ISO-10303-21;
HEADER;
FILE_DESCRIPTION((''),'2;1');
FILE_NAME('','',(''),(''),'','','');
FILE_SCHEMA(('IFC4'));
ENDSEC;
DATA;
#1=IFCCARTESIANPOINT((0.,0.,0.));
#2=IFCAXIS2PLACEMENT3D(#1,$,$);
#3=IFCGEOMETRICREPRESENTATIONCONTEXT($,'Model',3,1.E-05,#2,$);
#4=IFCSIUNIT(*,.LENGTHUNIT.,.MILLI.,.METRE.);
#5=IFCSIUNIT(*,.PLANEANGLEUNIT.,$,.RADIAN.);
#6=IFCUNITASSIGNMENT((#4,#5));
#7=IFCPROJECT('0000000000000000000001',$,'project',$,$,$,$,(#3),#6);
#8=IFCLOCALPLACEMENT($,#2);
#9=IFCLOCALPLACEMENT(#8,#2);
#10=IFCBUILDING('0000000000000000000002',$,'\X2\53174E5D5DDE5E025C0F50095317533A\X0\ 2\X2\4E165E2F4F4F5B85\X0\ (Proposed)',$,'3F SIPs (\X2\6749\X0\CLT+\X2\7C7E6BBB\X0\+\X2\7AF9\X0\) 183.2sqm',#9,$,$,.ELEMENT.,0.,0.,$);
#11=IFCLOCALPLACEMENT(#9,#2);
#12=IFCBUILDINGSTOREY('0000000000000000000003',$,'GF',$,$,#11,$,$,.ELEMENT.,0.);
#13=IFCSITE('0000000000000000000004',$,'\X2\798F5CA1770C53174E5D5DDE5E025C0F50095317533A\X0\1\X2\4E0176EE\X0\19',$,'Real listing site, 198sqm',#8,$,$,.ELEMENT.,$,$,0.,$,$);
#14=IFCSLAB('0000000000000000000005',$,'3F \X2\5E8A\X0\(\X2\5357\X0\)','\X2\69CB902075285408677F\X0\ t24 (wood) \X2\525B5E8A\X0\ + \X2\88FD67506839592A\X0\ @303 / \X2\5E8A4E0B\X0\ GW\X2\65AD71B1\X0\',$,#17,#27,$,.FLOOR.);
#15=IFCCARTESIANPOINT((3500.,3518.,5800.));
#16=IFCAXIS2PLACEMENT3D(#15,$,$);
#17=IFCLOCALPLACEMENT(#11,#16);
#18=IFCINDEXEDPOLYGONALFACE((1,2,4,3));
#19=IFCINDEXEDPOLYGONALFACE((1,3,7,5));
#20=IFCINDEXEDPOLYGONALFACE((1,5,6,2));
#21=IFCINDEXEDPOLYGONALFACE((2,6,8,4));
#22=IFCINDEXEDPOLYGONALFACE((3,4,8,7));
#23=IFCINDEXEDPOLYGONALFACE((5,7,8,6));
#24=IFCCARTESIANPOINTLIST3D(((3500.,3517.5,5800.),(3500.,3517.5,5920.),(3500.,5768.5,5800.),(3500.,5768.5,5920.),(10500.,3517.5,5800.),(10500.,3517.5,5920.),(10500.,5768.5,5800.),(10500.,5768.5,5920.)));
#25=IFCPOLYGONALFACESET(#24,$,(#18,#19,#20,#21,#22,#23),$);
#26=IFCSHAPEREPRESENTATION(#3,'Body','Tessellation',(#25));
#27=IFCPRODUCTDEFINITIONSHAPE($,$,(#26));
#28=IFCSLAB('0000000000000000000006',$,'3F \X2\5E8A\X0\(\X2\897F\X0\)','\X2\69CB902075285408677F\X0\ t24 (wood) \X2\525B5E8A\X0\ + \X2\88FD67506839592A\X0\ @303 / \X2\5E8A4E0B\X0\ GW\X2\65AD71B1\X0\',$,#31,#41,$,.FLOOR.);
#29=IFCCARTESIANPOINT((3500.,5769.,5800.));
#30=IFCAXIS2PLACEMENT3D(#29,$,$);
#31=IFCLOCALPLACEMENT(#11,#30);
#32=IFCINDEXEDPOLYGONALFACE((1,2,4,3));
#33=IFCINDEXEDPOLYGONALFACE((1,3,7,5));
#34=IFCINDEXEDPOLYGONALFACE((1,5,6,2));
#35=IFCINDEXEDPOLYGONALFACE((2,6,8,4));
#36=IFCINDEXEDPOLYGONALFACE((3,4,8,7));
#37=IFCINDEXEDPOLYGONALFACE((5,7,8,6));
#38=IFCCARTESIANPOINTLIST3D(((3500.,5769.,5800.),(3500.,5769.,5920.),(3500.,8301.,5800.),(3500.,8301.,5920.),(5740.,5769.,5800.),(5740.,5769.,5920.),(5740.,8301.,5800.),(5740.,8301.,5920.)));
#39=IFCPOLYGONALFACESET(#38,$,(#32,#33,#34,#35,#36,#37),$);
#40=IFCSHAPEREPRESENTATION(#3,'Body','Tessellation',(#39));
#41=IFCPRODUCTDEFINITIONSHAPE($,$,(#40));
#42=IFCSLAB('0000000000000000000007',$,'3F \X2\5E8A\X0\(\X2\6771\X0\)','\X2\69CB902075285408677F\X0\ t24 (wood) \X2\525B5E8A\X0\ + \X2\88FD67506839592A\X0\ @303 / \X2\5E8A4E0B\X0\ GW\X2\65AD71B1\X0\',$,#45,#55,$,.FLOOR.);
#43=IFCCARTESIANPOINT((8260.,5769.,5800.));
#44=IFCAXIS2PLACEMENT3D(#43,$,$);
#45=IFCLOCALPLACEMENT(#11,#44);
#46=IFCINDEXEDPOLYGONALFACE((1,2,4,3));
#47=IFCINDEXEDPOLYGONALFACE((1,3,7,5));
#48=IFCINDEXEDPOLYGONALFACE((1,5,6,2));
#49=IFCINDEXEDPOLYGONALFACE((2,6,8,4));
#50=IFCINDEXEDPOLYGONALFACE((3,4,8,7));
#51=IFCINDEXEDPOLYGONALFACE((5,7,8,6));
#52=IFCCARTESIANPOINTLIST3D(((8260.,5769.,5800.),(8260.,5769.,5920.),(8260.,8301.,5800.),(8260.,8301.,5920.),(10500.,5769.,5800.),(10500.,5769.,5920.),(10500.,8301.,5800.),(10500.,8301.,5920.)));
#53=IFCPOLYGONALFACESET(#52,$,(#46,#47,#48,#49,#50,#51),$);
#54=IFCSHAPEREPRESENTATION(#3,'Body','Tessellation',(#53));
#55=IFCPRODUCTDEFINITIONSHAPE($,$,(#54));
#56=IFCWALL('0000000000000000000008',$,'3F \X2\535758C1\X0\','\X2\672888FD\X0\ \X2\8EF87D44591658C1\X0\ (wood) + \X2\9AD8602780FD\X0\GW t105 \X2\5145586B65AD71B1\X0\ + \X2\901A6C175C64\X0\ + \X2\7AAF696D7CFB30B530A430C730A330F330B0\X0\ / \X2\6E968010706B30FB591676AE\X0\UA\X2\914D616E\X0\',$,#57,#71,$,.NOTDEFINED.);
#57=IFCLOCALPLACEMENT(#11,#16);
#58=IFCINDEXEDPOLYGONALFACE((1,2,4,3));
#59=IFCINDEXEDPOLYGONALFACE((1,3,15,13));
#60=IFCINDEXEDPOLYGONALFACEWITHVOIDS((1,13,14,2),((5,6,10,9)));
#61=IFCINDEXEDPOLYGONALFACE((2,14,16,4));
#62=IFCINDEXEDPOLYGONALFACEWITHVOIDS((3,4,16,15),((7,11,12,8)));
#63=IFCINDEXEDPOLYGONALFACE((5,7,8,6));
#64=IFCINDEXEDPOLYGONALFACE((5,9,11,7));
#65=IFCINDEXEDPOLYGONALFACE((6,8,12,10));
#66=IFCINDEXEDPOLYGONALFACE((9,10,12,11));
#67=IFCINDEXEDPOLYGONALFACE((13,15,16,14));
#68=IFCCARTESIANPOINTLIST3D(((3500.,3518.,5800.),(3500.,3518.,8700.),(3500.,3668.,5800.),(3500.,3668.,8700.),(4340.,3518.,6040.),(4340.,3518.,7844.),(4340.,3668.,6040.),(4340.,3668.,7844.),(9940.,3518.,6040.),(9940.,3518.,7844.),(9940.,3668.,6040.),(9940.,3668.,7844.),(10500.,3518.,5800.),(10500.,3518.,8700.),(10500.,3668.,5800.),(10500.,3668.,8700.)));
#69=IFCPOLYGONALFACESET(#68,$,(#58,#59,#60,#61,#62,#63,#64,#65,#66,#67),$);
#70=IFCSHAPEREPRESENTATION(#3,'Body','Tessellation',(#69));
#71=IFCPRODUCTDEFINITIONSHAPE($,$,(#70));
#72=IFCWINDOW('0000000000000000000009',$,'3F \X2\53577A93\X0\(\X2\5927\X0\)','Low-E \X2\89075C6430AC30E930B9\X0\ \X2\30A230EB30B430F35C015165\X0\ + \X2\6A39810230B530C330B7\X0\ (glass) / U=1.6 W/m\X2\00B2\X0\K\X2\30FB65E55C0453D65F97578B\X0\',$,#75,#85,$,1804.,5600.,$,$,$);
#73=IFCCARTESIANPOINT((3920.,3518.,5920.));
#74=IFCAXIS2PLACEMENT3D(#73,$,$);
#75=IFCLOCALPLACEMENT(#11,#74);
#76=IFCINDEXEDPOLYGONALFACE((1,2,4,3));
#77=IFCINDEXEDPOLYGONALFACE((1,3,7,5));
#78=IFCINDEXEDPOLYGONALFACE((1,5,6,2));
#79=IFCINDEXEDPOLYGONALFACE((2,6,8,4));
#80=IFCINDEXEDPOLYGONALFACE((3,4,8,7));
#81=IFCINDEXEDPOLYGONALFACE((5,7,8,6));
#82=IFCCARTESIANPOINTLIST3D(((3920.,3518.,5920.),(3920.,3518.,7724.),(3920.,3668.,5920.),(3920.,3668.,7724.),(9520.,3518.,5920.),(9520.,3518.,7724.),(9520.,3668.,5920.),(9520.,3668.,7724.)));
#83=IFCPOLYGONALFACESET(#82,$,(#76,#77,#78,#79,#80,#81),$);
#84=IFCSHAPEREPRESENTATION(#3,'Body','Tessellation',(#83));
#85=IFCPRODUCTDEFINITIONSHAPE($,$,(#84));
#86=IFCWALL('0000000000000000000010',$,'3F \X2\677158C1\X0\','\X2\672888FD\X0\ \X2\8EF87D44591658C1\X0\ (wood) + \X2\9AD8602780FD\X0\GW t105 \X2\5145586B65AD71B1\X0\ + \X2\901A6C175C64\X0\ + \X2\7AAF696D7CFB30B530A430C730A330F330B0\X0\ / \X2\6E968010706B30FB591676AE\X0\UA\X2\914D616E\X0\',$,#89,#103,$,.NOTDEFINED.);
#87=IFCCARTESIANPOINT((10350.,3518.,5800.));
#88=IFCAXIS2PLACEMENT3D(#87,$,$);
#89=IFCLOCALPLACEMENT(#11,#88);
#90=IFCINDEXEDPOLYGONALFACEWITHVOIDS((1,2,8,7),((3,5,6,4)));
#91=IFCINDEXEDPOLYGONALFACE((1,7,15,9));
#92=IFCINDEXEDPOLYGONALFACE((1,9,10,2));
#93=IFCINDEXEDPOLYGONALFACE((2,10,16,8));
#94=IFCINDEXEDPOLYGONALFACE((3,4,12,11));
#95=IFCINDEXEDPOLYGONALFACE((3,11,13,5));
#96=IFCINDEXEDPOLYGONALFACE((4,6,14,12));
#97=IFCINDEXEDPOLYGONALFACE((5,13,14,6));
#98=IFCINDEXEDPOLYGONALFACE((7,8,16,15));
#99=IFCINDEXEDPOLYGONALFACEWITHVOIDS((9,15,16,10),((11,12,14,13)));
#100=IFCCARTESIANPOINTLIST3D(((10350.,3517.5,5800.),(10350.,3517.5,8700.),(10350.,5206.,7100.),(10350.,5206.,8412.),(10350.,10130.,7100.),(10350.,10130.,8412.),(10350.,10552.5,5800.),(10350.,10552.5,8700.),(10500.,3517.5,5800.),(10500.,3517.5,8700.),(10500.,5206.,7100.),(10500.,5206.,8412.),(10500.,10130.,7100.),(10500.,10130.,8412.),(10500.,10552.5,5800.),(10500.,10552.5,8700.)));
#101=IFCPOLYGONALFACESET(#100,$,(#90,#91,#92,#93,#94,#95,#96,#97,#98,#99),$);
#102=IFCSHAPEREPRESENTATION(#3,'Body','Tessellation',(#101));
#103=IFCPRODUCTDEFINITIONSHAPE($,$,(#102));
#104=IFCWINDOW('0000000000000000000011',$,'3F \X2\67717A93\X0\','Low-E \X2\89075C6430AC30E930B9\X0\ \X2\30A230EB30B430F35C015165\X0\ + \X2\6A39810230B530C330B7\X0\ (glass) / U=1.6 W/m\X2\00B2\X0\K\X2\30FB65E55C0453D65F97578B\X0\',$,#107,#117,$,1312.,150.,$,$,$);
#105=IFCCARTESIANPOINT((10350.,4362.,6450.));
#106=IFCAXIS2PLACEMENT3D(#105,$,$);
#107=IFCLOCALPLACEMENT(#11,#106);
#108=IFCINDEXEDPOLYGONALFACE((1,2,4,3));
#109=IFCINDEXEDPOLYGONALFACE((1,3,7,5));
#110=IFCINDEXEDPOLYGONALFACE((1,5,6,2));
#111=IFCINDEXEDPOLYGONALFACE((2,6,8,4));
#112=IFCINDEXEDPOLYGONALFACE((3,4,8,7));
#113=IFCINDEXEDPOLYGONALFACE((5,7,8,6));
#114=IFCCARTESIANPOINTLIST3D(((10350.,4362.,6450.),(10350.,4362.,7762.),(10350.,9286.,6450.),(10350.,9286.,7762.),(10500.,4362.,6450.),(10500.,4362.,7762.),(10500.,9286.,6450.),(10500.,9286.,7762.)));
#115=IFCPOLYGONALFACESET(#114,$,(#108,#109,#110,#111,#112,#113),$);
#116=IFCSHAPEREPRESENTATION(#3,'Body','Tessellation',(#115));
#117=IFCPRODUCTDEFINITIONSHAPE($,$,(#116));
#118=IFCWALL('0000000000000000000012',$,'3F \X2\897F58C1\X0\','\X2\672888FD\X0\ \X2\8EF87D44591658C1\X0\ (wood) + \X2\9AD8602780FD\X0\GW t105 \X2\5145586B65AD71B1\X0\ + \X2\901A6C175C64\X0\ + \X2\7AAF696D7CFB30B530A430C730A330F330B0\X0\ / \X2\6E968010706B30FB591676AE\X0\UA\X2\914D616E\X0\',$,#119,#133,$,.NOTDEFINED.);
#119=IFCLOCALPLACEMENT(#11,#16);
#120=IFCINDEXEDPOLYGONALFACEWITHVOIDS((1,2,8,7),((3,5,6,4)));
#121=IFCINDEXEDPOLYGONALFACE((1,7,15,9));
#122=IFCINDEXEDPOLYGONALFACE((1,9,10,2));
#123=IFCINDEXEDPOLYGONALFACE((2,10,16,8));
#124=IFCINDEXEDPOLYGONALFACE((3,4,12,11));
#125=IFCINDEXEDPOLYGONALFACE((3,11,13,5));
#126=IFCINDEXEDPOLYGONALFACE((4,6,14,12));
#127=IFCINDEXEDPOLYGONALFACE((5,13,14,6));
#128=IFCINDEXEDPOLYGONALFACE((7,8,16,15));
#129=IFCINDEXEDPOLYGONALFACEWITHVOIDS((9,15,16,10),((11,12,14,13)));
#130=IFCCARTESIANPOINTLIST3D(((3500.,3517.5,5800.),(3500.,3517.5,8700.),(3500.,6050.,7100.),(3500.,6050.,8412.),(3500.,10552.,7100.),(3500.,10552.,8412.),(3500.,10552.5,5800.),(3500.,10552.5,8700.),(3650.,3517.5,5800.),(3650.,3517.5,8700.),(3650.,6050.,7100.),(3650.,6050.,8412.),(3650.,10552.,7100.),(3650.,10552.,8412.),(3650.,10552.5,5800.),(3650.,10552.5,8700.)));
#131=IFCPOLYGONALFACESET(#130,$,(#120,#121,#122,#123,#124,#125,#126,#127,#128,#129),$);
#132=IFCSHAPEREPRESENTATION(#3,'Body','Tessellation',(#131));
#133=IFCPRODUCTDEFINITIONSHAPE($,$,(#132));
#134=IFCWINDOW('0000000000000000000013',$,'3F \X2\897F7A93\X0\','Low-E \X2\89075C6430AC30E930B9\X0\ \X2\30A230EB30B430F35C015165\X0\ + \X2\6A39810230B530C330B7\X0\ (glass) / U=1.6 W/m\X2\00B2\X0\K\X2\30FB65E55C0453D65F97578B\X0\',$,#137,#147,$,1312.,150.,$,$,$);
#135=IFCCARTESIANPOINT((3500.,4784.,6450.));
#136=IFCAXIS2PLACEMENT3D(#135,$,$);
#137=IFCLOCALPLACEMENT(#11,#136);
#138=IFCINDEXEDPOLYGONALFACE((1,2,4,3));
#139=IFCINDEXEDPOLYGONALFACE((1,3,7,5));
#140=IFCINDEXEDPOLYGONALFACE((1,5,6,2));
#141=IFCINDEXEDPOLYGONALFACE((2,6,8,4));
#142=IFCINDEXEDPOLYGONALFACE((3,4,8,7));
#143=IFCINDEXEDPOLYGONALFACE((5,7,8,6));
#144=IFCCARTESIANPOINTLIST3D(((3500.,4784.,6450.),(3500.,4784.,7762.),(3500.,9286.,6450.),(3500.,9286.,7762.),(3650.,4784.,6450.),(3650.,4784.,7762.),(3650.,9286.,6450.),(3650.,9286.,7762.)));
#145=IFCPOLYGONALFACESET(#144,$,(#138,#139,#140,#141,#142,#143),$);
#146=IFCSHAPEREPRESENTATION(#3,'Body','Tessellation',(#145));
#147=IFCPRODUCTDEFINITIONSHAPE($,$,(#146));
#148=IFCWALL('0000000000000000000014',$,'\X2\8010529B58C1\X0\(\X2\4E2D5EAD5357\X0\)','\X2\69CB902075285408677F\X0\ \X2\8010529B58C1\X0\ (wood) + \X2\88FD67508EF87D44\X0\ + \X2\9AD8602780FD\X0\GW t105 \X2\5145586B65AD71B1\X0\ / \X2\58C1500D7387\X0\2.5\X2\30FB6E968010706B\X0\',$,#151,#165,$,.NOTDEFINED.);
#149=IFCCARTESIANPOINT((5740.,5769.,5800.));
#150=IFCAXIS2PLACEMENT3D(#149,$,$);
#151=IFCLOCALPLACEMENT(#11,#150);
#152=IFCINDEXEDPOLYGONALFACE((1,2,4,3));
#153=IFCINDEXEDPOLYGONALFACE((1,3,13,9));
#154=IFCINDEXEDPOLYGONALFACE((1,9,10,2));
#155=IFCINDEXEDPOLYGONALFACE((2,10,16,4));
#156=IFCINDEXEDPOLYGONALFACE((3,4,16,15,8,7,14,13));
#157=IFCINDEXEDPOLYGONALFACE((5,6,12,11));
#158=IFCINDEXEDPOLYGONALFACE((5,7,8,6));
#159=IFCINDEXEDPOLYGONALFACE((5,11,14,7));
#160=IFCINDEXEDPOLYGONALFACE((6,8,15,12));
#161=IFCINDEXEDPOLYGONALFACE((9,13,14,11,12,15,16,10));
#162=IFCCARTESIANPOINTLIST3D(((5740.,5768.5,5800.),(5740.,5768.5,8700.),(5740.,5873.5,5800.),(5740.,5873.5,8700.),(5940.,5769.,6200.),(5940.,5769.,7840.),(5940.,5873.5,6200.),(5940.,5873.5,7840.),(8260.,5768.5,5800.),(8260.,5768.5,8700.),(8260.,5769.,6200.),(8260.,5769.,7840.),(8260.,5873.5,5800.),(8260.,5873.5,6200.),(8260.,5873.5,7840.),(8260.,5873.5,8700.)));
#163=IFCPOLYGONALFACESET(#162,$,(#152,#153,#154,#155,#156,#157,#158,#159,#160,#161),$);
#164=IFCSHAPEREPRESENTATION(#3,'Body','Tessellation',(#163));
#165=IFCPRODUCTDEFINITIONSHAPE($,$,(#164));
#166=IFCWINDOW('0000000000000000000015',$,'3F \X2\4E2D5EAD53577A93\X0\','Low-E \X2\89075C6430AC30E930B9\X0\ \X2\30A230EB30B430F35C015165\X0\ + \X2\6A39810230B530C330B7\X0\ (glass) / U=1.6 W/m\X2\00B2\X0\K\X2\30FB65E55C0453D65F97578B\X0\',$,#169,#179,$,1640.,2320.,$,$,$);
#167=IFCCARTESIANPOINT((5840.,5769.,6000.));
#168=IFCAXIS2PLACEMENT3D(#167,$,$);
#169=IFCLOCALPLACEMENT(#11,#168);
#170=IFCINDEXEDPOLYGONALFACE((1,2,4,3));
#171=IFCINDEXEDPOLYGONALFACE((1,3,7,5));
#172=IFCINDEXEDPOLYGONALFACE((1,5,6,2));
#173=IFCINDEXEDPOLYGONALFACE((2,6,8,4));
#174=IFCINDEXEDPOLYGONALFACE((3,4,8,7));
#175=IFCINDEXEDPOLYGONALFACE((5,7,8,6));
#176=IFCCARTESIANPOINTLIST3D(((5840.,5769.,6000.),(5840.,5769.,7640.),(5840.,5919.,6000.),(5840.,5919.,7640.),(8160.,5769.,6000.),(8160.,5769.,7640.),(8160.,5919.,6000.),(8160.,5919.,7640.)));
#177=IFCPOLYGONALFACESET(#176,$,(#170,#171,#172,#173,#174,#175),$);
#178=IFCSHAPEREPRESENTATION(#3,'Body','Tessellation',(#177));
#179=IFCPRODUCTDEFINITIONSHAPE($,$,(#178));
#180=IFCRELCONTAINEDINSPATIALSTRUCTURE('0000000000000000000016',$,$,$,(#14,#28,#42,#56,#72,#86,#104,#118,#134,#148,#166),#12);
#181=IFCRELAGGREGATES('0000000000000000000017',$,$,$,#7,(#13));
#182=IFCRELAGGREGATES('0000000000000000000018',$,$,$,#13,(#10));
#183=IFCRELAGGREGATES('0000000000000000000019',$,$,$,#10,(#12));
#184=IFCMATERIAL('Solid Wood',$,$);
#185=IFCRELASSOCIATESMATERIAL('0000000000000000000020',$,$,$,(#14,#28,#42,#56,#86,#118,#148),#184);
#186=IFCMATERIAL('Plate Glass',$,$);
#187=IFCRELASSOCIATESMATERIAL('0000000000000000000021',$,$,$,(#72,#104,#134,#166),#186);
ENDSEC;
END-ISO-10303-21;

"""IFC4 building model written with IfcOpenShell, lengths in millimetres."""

from ifc_helpers import new_model, si_unit, frame, frame_2d, origin, place, context, project, spatial, rectangle, extrude, material, element, fill, save


model = new_model("IFC4")

# Units and contexts
model_context = context("Model", 3, precision=1e-05, world=origin())
ifc_project = project(units=[si_unit("LENGTHUNIT", "METRE", prefix="MILLI"), si_unit("PLANEANGLEUNIT", "RADIAN")], contexts=[model_context])

# Site, building, storey
site_placement = place(None, origin())
site = spatial("IfcSite", under=ifc_project, at=site_placement, Name="福岡県北九州市小倉北区1丁目19", ObjectType="Real listing site, 198sqm", CompositionType="ELEMENT", RefElevation=0.0)
building_placement = place(site_placement, origin())
building = spatial("IfcBuilding", under=site, at=building_placement, Name="北九州市小倉北区 2世帯住宅 (Proposed)", ObjectType="3F SIPs (杉CLT+籾殻+竹) 183.2sqm", CompositionType="ELEMENT", ElevationOfRefHeight=0.0, ElevationOfTerrain=0.0)
storey_placement = place(building_placement, origin())
storey = spatial("IfcBuildingStorey", under=building, at=storey_placement, Name="GF", CompositionType="ELEMENT", Elevation=0.0)

# Slabs
ifc_material_1 = material(Name="Solid Wood")
slab_1_placement = place(storey_placement, frame((3500.0, 3518.0, 5800.0)))
element("IfcSlab", 1, at=slab_1_placement, inside=storey, material=ifc_material_1, Name="3F 床(南)", Description="構造用合板 t24 (wood) 剛床 + 製材根太 @303 / 床下 GW断熱", PredefinedType="FLOOR", context=model_context, shape_type="SweptSolid", body=[
    extrude(rectangle(XDim=7000.0, YDim=2251.0, at=frame_2d((3500.0, 1125.0))), frame((3500.0, 3518.0, 5800.0)), (0.0, 0.0, 1.0), 120.0),
])
slab_2_placement = place(storey_placement, frame((3500.0, 5769.0, 5800.0)))
element("IfcSlab", 2, at=slab_2_placement, inside=storey, material=ifc_material_1, Name="3F 床(西)", Description="構造用合板 t24 (wood) 剛床 + 製材根太 @303 / 床下 GW断熱", PredefinedType="FLOOR", context=model_context, shape_type="SweptSolid", body=[
    extrude(rectangle(XDim=2240.0, YDim=2532.0, at=frame_2d((1120.0, 1266.0))), frame((3500.0, 5769.0, 5800.0)), (0.0, 0.0, 1.0), 120.0),
])
slab_3_placement = place(storey_placement, frame((8260.0, 5769.0, 5800.0)))
element("IfcSlab", 3, at=slab_3_placement, inside=storey, material=ifc_material_1, Name="3F 床(東)", Description="構造用合板 t24 (wood) 剛床 + 製材根太 @303 / 床下 GW断熱", PredefinedType="FLOOR", context=model_context, shape_type="SweptSolid", body=[
    extrude(rectangle(XDim=2240.0, YDim=2532.0, at=frame_2d((1120.0, 1266.0))), frame((8260.0, 5769.0, 5800.0)), (0.0, 0.0, 1.0), 120.0),
])

# Walls, openings, windows
wall_1_placement = place(storey_placement, frame((3500.0, 3518.0, 5800.0)))
wall_1 = element("IfcWall", 4, at=wall_1_placement, inside=storey, material=ifc_material_1, Name="3F 南壁", Description="木製 軸組外壁 (wood) + 高性能GW t105 充填断熱 + 通気層 + 窯業系サイディング / 準耐火・外皮UA配慮", PredefinedType="NOTDEFINED", context=model_context, shape_type="SweptSolid", body=[
    extrude(rectangle(XDim=7000.0, YDim=150.0, at=frame_2d((3500.0, 75.0))), frame((3500.0, 3518.0, 5800.0)), (0.0, 0.0, 1.0), 2900.0),
])
opening_1_placement = place(storey_placement, frame((3920.0, 3518.0, 5920.0)))
opening_1 = element("IfcOpeningElement", 5, at=opening_1_placement, cuts=wall_1, PredefinedType="NOTDEFINED", context=model_context, shape_type="SweptSolid", body=[
    extrude(rectangle(XDim=5600.0, YDim=150.0, at=frame_2d((2800.0, 75.0))), frame((3920.0, 3518.0, 5920.0)), (0.0, 0.0, 1.0), 1804.0),
])
ifc_material_2 = material(Name="Plate Glass")
window_1_placement = place(storey_placement, frame((3920.0, 3518.0, 5920.0)))
window_1 = element("IfcWindow", 6, at=window_1_placement, inside=storey, material=ifc_material_2, Name="3F 南窓(大)", Description="Low-E 複層ガラス アルゴン封入 + 樹脂サッシ (glass) / U=1.6 W/m²K・日射取得型", OverallHeight=1804.0, OverallWidth=5600.0, context=model_context, shape_type="SweptSolid", body=[
    extrude(rectangle(XDim=5600.0, YDim=150.0, at=frame_2d((2800.0, 75.0))), frame((3920.0, 3518.0, 5920.0)), (0.0, 0.0, 1.0), 1804.0),
])
fill(opening_1, window_1)
wall_2_placement = place(storey_placement, frame((10350.0, 3518.0, 5800.0)))
wall_2 = element("IfcWall", 7, at=wall_2_placement, inside=storey, material=ifc_material_1, Name="3F 東壁", Description="木製 軸組外壁 (wood) + 高性能GW t105 充填断熱 + 通気層 + 窯業系サイディング / 準耐火・外皮UA配慮", PredefinedType="NOTDEFINED", context=model_context, shape_type="SweptSolid", body=[
    extrude(rectangle(XDim=150.0, YDim=7035.0, at=frame_2d((75.0, 3517.0))), frame((10350.0, 3518.0, 5800.0)), (0.0, 0.0, 1.0), 2900.0),
])
opening_2_placement = place(storey_placement, frame((10350.0, 4362.0, 6450.0)))
opening_2 = element("IfcOpeningElement", 8, at=opening_2_placement, cuts=wall_2, PredefinedType="NOTDEFINED", context=model_context, shape_type="SweptSolid", body=[
    extrude(rectangle(XDim=150.0, YDim=4924.0, at=frame_2d((75.0, 2462.0))), frame((10350.0, 4362.0, 6450.0)), (0.0, 0.0, 1.0), 1312.0),
])
window_2_placement = place(storey_placement, frame((10350.0, 4362.0, 6450.0)))
window_2 = element("IfcWindow", 9, at=window_2_placement, inside=storey, material=ifc_material_2, Name="3F 東窓", Description="Low-E 複層ガラス アルゴン封入 + 樹脂サッシ (glass) / U=1.6 W/m²K・日射取得型", OverallHeight=1312.0, OverallWidth=150.0, context=model_context, shape_type="SweptSolid", body=[
    extrude(rectangle(XDim=150.0, YDim=4924.0, at=frame_2d((75.0, 2462.0))), frame((10350.0, 4362.0, 6450.0)), (0.0, 0.0, 1.0), 1312.0),
])
fill(opening_2, window_2)
wall_3_placement = place(storey_placement, frame((3500.0, 3518.0, 5800.0)))
wall_3 = element("IfcWall", 10, at=wall_3_placement, inside=storey, material=ifc_material_1, Name="3F 西壁", Description="木製 軸組外壁 (wood) + 高性能GW t105 充填断熱 + 通気層 + 窯業系サイディング / 準耐火・外皮UA配慮", PredefinedType="NOTDEFINED", context=model_context, shape_type="SweptSolid", body=[
    extrude(rectangle(XDim=150.0, YDim=7035.0, at=frame_2d((75.0, 3517.0))), frame((3500.0, 3518.0, 5800.0)), (0.0, 0.0, 1.0), 2900.0),
])
opening_3_placement = place(storey_placement, frame((3500.0, 4784.0, 6450.0)))
opening_3 = element("IfcOpeningElement", 11, at=opening_3_placement, cuts=wall_3, PredefinedType="NOTDEFINED", context=model_context, shape_type="SweptSolid", body=[
    extrude(rectangle(XDim=150.0, YDim=4502.0, at=frame_2d((75.0, 2251.0))), frame((3500.0, 4784.0, 6450.0)), (0.0, 0.0, 1.0), 1312.0),
])
window_3_placement = place(storey_placement, frame((3500.0, 4784.0, 6450.0)))
window_3 = element("IfcWindow", 12, at=window_3_placement, inside=storey, material=ifc_material_2, Name="3F 西窓", Description="Low-E 複層ガラス アルゴン封入 + 樹脂サッシ (glass) / U=1.6 W/m²K・日射取得型", OverallHeight=1312.0, OverallWidth=150.0, context=model_context, shape_type="SweptSolid", body=[
    extrude(rectangle(XDim=150.0, YDim=4502.0, at=frame_2d((75.0, 2251.0))), frame((3500.0, 4784.0, 6450.0)), (0.0, 0.0, 1.0), 1312.0),
])
fill(opening_3, window_3)
wall_4_placement = place(storey_placement, frame((5740.0, 5769.0, 5800.0)))
wall_4 = element("IfcWall", 13, at=wall_4_placement, inside=storey, material=ifc_material_1, Name="耐力壁(中庭南)", Description="構造用合板 耐力壁 (wood) + 製材軸組 + 高性能GW t105 充填断熱 / 壁倍率2.5・準耐火", PredefinedType="NOTDEFINED", context=model_context, shape_type="SweptSolid", body=[
    extrude(rectangle(XDim=2520.0, YDim=105.0, at=frame_2d((1260.0, 52.0))), frame((5740.0, 5769.0, 5800.0)), (0.0, 0.0, 1.0), 2900.0),
])
opening_4_placement = place(storey_placement, frame((5840.0, 5769.0, 6000.0)))
opening_4 = element("IfcOpeningElement", 14, at=opening_4_placement, cuts=wall_4, PredefinedType="NOTDEFINED", context=model_context, shape_type="SweptSolid", body=[
    extrude(rectangle(XDim=2320.0, YDim=150.0, at=frame_2d((1160.0, 75.0))), frame((5840.0, 5769.0, 6000.0)), (0.0, 0.0, 1.0), 1640.0),
])
window_4_placement = place(storey_placement, frame((5840.0, 5769.0, 6000.0)))
window_4 = element("IfcWindow", 15, at=window_4_placement, inside=storey, material=ifc_material_2, Name="3F 中庭南窓", Description="Low-E 複層ガラス アルゴン封入 + 樹脂サッシ (glass) / U=1.6 W/m²K・日射取得型", OverallHeight=1640.0, OverallWidth=2320.0, context=model_context, shape_type="SweptSolid", body=[
    extrude(rectangle(XDim=2320.0, YDim=150.0, at=frame_2d((1160.0, 75.0))), frame((5840.0, 5769.0, 6000.0)), (0.0, 0.0, 1.0), 1640.0),
])
fill(opening_4, window_4)

save(model, "model.ifc")
